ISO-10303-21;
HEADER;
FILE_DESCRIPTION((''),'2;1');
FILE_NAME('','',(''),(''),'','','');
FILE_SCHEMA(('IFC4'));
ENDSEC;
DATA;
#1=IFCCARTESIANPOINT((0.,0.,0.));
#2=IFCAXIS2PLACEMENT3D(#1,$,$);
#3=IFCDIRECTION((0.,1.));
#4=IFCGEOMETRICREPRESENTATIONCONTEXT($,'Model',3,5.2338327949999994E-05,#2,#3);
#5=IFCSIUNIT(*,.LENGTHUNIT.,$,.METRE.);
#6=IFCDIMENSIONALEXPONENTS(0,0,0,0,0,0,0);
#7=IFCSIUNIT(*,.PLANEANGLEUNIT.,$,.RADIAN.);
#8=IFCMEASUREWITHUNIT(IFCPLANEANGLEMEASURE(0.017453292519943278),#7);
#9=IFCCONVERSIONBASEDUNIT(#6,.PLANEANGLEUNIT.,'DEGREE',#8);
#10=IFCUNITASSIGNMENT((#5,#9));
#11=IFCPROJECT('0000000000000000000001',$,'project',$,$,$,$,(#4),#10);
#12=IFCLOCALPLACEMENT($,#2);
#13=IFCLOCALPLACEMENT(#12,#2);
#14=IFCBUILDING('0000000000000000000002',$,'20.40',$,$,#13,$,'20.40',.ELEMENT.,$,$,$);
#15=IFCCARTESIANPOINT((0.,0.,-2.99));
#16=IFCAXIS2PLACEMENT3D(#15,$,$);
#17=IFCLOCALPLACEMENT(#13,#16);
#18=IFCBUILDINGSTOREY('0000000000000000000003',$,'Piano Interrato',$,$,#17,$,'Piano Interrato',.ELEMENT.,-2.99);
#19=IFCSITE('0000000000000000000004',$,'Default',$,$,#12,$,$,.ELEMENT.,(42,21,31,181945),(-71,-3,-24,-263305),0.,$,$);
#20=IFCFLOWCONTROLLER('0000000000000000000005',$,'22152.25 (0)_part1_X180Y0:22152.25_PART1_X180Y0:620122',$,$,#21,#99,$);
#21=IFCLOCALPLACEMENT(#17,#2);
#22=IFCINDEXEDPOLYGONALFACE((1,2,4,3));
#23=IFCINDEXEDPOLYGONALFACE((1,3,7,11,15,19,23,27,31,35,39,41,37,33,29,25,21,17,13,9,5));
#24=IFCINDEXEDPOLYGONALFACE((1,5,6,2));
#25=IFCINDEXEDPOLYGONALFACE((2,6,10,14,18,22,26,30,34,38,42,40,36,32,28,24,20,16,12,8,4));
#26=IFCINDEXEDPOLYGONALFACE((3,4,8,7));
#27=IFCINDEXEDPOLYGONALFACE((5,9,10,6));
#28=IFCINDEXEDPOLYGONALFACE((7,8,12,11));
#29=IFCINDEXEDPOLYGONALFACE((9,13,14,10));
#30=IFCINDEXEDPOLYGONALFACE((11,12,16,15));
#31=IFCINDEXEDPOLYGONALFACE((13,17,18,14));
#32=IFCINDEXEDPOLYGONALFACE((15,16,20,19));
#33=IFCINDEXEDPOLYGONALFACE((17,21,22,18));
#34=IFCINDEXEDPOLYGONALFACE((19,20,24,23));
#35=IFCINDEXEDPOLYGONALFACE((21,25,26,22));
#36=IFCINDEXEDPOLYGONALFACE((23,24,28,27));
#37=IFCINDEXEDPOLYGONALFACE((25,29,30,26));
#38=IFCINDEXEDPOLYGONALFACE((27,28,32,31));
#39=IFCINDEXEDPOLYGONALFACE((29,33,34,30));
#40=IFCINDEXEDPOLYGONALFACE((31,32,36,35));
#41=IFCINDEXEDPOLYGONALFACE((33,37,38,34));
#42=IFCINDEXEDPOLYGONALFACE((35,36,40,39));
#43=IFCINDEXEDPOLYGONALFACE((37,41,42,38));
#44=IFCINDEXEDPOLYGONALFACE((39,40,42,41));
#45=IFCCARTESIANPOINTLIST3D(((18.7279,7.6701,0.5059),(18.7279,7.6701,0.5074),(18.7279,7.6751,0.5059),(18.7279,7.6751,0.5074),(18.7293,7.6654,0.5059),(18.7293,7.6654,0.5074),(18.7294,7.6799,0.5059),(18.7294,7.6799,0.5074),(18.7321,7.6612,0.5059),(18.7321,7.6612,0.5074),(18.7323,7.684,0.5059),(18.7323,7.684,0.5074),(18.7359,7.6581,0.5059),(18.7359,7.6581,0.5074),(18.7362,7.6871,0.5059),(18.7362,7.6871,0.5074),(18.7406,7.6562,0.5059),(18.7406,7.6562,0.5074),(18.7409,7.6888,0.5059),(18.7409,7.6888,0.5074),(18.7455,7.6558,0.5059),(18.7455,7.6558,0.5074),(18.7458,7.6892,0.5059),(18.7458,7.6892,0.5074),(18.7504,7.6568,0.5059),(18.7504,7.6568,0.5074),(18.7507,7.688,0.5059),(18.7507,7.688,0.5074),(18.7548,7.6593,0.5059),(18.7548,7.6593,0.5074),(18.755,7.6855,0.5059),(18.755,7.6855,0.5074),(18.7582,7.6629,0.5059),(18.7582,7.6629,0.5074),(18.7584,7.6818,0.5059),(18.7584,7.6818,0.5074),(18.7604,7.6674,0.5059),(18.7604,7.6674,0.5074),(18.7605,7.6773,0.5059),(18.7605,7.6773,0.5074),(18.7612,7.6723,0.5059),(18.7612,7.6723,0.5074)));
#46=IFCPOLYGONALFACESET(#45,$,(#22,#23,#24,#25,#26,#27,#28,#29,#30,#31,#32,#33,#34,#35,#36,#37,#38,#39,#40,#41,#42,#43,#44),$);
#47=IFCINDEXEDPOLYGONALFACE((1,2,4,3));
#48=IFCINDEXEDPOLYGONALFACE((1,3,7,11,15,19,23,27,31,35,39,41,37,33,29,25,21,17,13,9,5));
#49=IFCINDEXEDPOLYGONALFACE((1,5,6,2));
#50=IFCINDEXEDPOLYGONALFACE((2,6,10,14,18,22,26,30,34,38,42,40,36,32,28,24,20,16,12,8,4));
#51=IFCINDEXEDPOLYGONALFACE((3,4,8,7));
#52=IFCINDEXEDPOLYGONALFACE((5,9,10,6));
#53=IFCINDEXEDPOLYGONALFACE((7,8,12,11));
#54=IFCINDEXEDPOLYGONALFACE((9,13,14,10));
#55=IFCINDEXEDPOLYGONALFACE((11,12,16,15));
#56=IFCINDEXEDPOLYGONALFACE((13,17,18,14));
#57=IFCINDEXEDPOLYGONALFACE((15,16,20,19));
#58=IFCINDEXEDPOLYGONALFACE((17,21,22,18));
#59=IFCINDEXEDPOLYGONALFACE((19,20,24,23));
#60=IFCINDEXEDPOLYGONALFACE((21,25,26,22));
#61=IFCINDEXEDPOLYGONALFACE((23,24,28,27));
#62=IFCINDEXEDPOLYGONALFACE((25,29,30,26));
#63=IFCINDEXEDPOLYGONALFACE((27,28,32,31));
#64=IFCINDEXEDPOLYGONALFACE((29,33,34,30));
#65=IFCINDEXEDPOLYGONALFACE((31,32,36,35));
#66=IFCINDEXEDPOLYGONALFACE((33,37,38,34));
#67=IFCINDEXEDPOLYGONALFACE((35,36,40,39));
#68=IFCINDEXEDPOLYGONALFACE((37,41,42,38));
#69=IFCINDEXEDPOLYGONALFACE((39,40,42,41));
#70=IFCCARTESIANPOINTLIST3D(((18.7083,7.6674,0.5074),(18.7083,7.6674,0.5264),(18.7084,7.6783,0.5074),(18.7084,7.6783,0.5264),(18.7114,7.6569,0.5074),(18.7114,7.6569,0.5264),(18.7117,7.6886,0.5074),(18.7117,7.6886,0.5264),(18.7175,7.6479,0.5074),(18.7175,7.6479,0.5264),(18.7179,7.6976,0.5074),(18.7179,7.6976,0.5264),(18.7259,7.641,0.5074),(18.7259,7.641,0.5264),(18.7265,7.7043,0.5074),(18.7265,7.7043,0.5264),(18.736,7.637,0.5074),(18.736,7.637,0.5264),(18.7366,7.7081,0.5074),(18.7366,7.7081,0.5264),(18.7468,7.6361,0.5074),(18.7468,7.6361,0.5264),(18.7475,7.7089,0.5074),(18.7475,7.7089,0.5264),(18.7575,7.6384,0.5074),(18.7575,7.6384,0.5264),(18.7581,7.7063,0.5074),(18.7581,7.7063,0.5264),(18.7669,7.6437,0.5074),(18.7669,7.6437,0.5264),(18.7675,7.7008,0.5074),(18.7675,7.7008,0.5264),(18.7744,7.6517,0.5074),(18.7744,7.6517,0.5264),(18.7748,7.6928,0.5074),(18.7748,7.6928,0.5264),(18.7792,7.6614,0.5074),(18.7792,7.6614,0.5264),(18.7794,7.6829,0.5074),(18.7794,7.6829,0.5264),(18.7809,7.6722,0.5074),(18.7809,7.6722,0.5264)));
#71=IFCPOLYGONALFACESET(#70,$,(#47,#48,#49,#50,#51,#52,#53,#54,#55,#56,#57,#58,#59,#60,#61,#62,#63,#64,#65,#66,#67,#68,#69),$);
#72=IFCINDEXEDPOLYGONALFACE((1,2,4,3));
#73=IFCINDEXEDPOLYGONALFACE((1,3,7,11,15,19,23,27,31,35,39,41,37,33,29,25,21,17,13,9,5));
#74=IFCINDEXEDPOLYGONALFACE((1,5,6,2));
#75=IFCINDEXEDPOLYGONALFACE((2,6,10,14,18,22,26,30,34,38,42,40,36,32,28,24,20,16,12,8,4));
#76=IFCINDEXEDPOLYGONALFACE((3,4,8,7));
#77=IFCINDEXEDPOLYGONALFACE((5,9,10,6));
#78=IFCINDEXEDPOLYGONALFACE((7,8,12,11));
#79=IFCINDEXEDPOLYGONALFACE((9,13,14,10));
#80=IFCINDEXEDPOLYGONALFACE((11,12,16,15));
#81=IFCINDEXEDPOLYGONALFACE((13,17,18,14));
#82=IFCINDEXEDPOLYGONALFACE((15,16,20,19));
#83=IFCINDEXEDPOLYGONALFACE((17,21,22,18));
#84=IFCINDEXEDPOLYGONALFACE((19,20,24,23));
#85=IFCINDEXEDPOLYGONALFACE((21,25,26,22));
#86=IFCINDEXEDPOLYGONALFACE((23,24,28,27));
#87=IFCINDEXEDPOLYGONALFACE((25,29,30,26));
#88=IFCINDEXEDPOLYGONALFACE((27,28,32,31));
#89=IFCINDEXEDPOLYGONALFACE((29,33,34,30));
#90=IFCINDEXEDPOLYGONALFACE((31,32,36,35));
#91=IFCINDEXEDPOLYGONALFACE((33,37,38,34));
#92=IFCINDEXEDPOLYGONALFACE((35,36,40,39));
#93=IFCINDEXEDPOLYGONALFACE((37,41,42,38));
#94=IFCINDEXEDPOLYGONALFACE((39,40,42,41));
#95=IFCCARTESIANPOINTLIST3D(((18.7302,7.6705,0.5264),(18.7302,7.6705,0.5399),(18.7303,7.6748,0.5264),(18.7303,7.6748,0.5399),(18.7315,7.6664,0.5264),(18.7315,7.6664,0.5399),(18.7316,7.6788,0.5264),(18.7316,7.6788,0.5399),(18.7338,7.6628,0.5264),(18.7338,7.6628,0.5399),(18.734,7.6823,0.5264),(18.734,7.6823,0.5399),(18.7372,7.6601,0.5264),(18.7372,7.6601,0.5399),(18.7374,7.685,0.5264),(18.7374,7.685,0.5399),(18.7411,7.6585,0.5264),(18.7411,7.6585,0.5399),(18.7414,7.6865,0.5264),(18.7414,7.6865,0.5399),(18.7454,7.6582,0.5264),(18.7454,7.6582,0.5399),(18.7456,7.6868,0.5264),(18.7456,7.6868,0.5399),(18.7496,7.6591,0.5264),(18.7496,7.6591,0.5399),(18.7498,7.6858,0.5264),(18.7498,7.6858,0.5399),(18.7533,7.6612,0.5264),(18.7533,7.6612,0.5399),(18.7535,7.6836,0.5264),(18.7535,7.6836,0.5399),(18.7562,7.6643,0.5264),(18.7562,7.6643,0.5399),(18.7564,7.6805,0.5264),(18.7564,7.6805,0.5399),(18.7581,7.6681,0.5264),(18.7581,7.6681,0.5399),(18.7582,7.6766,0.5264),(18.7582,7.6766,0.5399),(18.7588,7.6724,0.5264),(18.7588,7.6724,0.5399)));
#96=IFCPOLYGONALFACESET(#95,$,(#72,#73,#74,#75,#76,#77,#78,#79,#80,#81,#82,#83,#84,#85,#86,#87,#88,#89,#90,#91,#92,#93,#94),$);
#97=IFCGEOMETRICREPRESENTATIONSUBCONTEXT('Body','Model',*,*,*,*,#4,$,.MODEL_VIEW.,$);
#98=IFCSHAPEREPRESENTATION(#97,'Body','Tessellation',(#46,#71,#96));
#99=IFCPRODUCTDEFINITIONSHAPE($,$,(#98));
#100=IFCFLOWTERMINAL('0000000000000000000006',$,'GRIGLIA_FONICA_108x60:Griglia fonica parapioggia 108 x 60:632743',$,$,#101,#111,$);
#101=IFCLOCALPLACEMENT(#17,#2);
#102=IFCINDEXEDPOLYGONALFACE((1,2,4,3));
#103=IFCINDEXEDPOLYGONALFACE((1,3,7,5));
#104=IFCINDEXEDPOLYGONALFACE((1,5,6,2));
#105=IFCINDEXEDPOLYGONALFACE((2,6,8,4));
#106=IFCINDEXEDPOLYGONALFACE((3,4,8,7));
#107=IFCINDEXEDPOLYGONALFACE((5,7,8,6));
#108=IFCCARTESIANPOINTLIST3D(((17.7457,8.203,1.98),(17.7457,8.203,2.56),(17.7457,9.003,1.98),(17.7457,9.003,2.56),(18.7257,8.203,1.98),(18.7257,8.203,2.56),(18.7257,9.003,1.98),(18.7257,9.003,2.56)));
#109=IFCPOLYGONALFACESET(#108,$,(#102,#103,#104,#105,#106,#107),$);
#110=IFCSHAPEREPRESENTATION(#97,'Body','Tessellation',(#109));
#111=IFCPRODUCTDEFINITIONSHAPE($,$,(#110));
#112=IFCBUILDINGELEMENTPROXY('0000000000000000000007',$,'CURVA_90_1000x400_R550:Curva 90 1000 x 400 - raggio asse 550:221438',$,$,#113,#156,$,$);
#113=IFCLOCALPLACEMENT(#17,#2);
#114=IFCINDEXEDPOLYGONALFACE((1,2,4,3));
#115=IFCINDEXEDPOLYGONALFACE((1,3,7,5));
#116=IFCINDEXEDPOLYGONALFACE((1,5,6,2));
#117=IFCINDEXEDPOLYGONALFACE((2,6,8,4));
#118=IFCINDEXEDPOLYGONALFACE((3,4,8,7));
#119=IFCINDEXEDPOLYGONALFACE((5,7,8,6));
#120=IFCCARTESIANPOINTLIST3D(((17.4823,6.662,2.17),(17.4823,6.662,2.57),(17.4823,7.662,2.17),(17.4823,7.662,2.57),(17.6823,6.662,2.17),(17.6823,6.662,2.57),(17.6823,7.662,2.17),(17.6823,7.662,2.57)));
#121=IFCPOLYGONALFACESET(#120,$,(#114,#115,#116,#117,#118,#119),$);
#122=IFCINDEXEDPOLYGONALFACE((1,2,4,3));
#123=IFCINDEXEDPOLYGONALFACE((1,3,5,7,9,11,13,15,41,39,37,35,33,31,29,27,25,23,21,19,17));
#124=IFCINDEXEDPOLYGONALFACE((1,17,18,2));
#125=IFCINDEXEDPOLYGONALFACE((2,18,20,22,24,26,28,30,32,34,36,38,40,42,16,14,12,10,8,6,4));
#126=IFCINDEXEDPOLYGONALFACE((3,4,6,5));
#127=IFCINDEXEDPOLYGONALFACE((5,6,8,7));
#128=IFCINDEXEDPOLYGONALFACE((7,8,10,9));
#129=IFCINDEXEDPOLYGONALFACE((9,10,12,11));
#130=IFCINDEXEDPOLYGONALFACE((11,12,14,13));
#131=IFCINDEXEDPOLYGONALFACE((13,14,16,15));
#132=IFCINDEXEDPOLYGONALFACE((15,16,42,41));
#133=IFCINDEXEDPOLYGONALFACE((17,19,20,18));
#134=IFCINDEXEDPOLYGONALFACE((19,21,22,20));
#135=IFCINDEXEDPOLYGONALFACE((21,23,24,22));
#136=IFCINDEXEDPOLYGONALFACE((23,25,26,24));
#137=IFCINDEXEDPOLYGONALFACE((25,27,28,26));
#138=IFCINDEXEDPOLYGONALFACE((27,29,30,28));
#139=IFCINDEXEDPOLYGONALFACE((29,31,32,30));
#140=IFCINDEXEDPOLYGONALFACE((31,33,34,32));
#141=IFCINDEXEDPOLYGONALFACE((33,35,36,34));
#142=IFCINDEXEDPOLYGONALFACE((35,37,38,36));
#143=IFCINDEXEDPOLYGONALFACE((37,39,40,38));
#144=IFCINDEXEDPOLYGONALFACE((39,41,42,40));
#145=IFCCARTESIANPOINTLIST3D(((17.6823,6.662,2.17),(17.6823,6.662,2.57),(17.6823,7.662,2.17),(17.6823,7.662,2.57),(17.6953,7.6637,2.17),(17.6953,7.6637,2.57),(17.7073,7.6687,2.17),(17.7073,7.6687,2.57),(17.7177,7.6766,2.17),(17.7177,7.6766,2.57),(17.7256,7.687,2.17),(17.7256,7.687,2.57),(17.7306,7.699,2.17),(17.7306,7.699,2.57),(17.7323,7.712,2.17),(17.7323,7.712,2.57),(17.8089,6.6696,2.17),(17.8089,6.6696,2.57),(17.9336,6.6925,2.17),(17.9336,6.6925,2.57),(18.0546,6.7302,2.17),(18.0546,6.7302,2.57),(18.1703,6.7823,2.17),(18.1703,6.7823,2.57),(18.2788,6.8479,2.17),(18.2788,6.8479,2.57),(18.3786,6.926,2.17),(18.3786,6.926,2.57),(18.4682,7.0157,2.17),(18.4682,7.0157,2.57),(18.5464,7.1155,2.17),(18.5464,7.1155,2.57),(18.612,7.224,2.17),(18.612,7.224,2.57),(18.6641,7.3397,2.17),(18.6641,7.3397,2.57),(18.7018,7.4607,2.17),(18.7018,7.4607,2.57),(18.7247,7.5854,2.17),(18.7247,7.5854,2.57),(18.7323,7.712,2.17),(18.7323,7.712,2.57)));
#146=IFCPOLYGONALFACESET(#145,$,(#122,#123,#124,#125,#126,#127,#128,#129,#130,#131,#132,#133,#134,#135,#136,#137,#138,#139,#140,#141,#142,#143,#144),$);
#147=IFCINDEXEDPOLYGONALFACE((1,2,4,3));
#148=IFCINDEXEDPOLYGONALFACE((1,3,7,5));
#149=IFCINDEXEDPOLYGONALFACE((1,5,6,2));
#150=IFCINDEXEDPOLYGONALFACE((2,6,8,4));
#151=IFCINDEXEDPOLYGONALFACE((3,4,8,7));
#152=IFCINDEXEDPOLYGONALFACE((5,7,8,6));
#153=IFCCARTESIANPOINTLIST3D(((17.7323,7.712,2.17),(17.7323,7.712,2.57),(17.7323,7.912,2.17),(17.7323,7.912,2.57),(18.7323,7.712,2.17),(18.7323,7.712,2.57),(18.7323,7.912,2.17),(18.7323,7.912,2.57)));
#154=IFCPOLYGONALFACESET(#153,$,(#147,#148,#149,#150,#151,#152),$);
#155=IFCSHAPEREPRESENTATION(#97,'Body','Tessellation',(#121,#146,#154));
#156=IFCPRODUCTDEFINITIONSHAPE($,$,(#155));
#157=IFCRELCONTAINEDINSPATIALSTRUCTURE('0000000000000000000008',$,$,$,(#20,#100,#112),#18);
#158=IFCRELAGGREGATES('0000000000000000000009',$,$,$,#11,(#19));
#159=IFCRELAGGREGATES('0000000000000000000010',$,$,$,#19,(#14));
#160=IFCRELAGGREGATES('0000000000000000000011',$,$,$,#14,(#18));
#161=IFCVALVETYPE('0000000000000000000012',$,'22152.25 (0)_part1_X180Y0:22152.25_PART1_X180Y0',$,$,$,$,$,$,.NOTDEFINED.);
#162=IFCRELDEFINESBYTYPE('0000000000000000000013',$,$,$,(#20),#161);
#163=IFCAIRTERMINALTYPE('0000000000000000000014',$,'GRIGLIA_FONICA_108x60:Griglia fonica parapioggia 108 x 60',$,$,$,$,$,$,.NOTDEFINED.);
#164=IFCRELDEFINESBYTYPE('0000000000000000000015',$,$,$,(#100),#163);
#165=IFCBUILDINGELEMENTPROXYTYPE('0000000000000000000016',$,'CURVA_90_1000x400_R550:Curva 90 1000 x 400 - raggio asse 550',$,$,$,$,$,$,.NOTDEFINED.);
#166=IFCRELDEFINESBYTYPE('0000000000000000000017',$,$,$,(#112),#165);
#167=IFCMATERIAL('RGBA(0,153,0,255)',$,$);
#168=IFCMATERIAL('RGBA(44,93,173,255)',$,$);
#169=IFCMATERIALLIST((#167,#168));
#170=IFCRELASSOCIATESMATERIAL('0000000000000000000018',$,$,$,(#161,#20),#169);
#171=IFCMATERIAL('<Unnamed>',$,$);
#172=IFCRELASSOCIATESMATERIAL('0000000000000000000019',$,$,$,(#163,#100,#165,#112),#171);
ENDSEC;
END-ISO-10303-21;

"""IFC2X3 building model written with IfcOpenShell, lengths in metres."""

from ifc_helpers import new_model, entity, si_unit, converted_unit, direction, frame, frame_2d, origin, origin_2d_with_axis, place, context, subcontext, project, spatial, polyline, circle_curve, parameter, trimmed, segment, composite_curve, rectangle, circle, outline, extrude, source, transform, mapped, material, material_list, type_object, type_shapes, element, save


model = new_model("IFC2X3")

# Units and contexts
model_context = context("Model", 3, precision=5.2338327949999994e-05, world=origin(), true_north=direction((0.0, 1.0)))
body_context = subcontext(model_context, "Body", "Model", "MODEL_VIEW")
ifc_project = project(units=[si_unit("LENGTHUNIT", "METRE"), converted_unit("PLANEANGLEUNIT", "DEGREE", entity("IfcPlaneAngleMeasure", 0.017453292519943278), si_unit("PLANEANGLEUNIT", "RADIAN"), dimensions=[0, 0, 0, 0, 0, 0, 0])], contexts=[model_context])

# Site, building, storey
site_placement = place(None, origin())
site = spatial("IfcSite", under=ifc_project, at=site_placement, Name="Default", CompositionType="ELEMENT", RefLatitude=(42, 21, 31, 181945), RefLongitude=(-71, -3, -24, -263305), RefElevation=0.0)
building_placement = place(site_placement, origin())
building = spatial("IfcBuilding", under=site, at=building_placement, Name="20.40", LongName="20.40", CompositionType="ELEMENT")
storey_placement = place(building_placement, frame((0.0, 0.0, -2.99)))
storey = spatial("IfcBuildingStorey", under=building, at=storey_placement, Name="Piano Interrato", LongName="Piano Interrato", CompositionType="ELEMENT", Elevation=-2.99)

# Shared definitions
ifc_material_1 = material(Name="<Unnamed>")

# Flow controller
ifc_material_2 = material(Name="RGBA(0,153,0,255)")
ifc_material_3 = material(Name="RGBA(44,93,173,255)")
ifc_material_list_1 = material_list([ifc_material_2, ifc_material_3])
valve_type_1 = type_object("IfcValveType", Name="22152.25 (0)_part1_X180Y0:22152.25_PART1_X180Y0", PredefinedType="NOTDEFINED", material=ifc_material_list_1)
shared_shape_1 = source(origin(), body_context, "Body", "SweptSolid", [
    extrude(circle(Radius=0.0168, at=frame_2d((0.0, 0.0), x_axis=(1.0, 0.0))), frame((0.0, 0.0, -0.034), z_axis=(0.0, 0.0, 1.0), x_axis=(0.0, -1.0, 0.0)), (0.0, 0.0, 1.0), 0.0015),
    extrude(circle(Radius=0.0365, at=frame_2d((0.0, 0.0), x_axis=(1.0, 0.0))), frame((0.0, 0.0, -0.0325), z_axis=(0.0, 0.0, 1.0), x_axis=(0.0, -1.0, 0.0)), (0.0, 0.0, 1.0), 0.019),
    extrude(circle(Radius=0.0144, at=frame_2d((0.0, 0.0), x_axis=(1.0, 0.0))), frame((0.0, 0.0, -0.0135), z_axis=(0.0, 0.0, 1.0), x_axis=(0.0, -1.0, 0.0)), (0.0, 0.0, 1.0), 0.0135),
])
type_shapes(valve_type_1, [shared_shape_1])
flow_controller_1_placement = place(storey_placement, frame((18.7444, 7.6725, 0.5399), z_axis=(0.0, 0.0, 1.0), x_axis=(0.009014, 0.999959, 0.0)))
element("IfcFlowController", 1, at=flow_controller_1_placement, inside=storey, type_object=valve_type_1, material=ifc_material_list_1, Name="22152.25 (0)_part1_X180Y0:22152.25_PART1_X180Y0:620122", context=body_context, shape_type="MappedRepresentation", body=[
    mapped(shared_shape_1, transform((0.0, 0.0, 0.0), scale=1.0)),
])

# Flow terminal
air_terminal_type = type_object("IfcAirTerminalType", Name="GRIGLIA_FONICA_108x60:Griglia fonica parapioggia 108 x 60", PredefinedType="NOTDEFINED", material=ifc_material_1)
shared_shape_2 = source(origin(), body_context, "Body", "SweptSolid", [
    extrude(rectangle(XDim=0.8, YDim=0.98, at=origin_2d_with_axis()), frame((0.0, 0.4, -0.29), z_axis=(0.0, 0.0, 1.0), x_axis=(0.0, -1.0, 0.0)), (0.0, 0.0, 1.0), 0.58),
])
type_shapes(air_terminal_type, [shared_shape_2])
flow_terminal_placement = place(storey_placement, frame((18.2357, 8.203, 2.27)))
element("IfcFlowTerminal", 2, at=flow_terminal_placement, inside=storey, type_object=air_terminal_type, material=ifc_material_1, Name="GRIGLIA_FONICA_108x60:Griglia fonica parapioggia 108 x 60:632743", context=body_context, shape_type="MappedRepresentation", body=[
    mapped(shared_shape_2, transform((0.0, 0.0, 0.0), scale=1.0)),
])

# Building element proxy
building_element_proxy_type_1 = type_object("IfcBuildingElementProxyType", Name="CURVA_90_1000x400_R550:Curva 90 1000 x 400 - raggio asse 550", PredefinedType="NOTDEFINED", material=ifc_material_1)
shared_shape_3 = source(origin(), body_context, "Body", "SweptSolid", [
    extrude(rectangle(XDim=0.2, YDim=1.0, at=origin_2d_with_axis()), frame((0.55, -0.1, -0.2), z_axis=(0.0, 0.0, 1.0), x_axis=(0.0, -1.0, 0.0)), (0.0, 0.0, 1.0), 0.4),
    extrude(outline(composite_curve([segment(polyline([(-0.775, -0.275), (0.225, -0.275)]), True, "CONTINUOUS"), segment(trimmed(circle_curve(frame_2d((0.275, -0.275), x_axis=(0.0, 1.0)), 0.05), [parameter(0.0)], [parameter(90.0)], True, "PARAMETER"), False, "CONTINUOUS"), segment(polyline([(0.275, -0.225), (0.275, 0.775)]), True, "CONTINUOUS"), segment(trimmed(circle_curve(frame_2d((0.275, -0.275), x_axis=(0.0, 1.0)), 1.05), [parameter(0.0)], [parameter(90.0)], True, "PARAMETER"), True, "CONTINUOUS")], self_intersect=False)), frame((0.275, 0.275, -0.2), z_axis=(0.0, 0.0, 1.0), x_axis=(0.0, -1.0, 0.0)), (0.0, 0.0, 1.0), 0.4),
    extrude(rectangle(XDim=0.2, YDim=1.0, at=origin_2d_with_axis()), frame((-0.1, 0.55, -0.2), z_axis=(0.0, 0.0, 1.0), x_axis=(-1.0, 0.0, 0.0)), (0.0, 0.0, 1.0), 0.4),
])
type_shapes(building_element_proxy_type_1, [shared_shape_3])
proxy_1_placement = place(storey_placement, frame((17.6823, 7.712, 2.37), z_axis=(0.0, 0.0, 1.0), x_axis=(0.0, -1.0, 0.0)))
element("IfcBuildingElementProxy", 3, at=proxy_1_placement, inside=storey, type_object=building_element_proxy_type_1, material=ifc_material_1, Name="CURVA_90_1000x400_R550:Curva 90 1000 x 400 - raggio asse 550:221438", context=body_context, shape_type="MappedRepresentation", body=[
    mapped(shared_shape_3, transform((0.0, 0.0, 0.0), scale=1.0)),
])

save(model, "model.ifc")
